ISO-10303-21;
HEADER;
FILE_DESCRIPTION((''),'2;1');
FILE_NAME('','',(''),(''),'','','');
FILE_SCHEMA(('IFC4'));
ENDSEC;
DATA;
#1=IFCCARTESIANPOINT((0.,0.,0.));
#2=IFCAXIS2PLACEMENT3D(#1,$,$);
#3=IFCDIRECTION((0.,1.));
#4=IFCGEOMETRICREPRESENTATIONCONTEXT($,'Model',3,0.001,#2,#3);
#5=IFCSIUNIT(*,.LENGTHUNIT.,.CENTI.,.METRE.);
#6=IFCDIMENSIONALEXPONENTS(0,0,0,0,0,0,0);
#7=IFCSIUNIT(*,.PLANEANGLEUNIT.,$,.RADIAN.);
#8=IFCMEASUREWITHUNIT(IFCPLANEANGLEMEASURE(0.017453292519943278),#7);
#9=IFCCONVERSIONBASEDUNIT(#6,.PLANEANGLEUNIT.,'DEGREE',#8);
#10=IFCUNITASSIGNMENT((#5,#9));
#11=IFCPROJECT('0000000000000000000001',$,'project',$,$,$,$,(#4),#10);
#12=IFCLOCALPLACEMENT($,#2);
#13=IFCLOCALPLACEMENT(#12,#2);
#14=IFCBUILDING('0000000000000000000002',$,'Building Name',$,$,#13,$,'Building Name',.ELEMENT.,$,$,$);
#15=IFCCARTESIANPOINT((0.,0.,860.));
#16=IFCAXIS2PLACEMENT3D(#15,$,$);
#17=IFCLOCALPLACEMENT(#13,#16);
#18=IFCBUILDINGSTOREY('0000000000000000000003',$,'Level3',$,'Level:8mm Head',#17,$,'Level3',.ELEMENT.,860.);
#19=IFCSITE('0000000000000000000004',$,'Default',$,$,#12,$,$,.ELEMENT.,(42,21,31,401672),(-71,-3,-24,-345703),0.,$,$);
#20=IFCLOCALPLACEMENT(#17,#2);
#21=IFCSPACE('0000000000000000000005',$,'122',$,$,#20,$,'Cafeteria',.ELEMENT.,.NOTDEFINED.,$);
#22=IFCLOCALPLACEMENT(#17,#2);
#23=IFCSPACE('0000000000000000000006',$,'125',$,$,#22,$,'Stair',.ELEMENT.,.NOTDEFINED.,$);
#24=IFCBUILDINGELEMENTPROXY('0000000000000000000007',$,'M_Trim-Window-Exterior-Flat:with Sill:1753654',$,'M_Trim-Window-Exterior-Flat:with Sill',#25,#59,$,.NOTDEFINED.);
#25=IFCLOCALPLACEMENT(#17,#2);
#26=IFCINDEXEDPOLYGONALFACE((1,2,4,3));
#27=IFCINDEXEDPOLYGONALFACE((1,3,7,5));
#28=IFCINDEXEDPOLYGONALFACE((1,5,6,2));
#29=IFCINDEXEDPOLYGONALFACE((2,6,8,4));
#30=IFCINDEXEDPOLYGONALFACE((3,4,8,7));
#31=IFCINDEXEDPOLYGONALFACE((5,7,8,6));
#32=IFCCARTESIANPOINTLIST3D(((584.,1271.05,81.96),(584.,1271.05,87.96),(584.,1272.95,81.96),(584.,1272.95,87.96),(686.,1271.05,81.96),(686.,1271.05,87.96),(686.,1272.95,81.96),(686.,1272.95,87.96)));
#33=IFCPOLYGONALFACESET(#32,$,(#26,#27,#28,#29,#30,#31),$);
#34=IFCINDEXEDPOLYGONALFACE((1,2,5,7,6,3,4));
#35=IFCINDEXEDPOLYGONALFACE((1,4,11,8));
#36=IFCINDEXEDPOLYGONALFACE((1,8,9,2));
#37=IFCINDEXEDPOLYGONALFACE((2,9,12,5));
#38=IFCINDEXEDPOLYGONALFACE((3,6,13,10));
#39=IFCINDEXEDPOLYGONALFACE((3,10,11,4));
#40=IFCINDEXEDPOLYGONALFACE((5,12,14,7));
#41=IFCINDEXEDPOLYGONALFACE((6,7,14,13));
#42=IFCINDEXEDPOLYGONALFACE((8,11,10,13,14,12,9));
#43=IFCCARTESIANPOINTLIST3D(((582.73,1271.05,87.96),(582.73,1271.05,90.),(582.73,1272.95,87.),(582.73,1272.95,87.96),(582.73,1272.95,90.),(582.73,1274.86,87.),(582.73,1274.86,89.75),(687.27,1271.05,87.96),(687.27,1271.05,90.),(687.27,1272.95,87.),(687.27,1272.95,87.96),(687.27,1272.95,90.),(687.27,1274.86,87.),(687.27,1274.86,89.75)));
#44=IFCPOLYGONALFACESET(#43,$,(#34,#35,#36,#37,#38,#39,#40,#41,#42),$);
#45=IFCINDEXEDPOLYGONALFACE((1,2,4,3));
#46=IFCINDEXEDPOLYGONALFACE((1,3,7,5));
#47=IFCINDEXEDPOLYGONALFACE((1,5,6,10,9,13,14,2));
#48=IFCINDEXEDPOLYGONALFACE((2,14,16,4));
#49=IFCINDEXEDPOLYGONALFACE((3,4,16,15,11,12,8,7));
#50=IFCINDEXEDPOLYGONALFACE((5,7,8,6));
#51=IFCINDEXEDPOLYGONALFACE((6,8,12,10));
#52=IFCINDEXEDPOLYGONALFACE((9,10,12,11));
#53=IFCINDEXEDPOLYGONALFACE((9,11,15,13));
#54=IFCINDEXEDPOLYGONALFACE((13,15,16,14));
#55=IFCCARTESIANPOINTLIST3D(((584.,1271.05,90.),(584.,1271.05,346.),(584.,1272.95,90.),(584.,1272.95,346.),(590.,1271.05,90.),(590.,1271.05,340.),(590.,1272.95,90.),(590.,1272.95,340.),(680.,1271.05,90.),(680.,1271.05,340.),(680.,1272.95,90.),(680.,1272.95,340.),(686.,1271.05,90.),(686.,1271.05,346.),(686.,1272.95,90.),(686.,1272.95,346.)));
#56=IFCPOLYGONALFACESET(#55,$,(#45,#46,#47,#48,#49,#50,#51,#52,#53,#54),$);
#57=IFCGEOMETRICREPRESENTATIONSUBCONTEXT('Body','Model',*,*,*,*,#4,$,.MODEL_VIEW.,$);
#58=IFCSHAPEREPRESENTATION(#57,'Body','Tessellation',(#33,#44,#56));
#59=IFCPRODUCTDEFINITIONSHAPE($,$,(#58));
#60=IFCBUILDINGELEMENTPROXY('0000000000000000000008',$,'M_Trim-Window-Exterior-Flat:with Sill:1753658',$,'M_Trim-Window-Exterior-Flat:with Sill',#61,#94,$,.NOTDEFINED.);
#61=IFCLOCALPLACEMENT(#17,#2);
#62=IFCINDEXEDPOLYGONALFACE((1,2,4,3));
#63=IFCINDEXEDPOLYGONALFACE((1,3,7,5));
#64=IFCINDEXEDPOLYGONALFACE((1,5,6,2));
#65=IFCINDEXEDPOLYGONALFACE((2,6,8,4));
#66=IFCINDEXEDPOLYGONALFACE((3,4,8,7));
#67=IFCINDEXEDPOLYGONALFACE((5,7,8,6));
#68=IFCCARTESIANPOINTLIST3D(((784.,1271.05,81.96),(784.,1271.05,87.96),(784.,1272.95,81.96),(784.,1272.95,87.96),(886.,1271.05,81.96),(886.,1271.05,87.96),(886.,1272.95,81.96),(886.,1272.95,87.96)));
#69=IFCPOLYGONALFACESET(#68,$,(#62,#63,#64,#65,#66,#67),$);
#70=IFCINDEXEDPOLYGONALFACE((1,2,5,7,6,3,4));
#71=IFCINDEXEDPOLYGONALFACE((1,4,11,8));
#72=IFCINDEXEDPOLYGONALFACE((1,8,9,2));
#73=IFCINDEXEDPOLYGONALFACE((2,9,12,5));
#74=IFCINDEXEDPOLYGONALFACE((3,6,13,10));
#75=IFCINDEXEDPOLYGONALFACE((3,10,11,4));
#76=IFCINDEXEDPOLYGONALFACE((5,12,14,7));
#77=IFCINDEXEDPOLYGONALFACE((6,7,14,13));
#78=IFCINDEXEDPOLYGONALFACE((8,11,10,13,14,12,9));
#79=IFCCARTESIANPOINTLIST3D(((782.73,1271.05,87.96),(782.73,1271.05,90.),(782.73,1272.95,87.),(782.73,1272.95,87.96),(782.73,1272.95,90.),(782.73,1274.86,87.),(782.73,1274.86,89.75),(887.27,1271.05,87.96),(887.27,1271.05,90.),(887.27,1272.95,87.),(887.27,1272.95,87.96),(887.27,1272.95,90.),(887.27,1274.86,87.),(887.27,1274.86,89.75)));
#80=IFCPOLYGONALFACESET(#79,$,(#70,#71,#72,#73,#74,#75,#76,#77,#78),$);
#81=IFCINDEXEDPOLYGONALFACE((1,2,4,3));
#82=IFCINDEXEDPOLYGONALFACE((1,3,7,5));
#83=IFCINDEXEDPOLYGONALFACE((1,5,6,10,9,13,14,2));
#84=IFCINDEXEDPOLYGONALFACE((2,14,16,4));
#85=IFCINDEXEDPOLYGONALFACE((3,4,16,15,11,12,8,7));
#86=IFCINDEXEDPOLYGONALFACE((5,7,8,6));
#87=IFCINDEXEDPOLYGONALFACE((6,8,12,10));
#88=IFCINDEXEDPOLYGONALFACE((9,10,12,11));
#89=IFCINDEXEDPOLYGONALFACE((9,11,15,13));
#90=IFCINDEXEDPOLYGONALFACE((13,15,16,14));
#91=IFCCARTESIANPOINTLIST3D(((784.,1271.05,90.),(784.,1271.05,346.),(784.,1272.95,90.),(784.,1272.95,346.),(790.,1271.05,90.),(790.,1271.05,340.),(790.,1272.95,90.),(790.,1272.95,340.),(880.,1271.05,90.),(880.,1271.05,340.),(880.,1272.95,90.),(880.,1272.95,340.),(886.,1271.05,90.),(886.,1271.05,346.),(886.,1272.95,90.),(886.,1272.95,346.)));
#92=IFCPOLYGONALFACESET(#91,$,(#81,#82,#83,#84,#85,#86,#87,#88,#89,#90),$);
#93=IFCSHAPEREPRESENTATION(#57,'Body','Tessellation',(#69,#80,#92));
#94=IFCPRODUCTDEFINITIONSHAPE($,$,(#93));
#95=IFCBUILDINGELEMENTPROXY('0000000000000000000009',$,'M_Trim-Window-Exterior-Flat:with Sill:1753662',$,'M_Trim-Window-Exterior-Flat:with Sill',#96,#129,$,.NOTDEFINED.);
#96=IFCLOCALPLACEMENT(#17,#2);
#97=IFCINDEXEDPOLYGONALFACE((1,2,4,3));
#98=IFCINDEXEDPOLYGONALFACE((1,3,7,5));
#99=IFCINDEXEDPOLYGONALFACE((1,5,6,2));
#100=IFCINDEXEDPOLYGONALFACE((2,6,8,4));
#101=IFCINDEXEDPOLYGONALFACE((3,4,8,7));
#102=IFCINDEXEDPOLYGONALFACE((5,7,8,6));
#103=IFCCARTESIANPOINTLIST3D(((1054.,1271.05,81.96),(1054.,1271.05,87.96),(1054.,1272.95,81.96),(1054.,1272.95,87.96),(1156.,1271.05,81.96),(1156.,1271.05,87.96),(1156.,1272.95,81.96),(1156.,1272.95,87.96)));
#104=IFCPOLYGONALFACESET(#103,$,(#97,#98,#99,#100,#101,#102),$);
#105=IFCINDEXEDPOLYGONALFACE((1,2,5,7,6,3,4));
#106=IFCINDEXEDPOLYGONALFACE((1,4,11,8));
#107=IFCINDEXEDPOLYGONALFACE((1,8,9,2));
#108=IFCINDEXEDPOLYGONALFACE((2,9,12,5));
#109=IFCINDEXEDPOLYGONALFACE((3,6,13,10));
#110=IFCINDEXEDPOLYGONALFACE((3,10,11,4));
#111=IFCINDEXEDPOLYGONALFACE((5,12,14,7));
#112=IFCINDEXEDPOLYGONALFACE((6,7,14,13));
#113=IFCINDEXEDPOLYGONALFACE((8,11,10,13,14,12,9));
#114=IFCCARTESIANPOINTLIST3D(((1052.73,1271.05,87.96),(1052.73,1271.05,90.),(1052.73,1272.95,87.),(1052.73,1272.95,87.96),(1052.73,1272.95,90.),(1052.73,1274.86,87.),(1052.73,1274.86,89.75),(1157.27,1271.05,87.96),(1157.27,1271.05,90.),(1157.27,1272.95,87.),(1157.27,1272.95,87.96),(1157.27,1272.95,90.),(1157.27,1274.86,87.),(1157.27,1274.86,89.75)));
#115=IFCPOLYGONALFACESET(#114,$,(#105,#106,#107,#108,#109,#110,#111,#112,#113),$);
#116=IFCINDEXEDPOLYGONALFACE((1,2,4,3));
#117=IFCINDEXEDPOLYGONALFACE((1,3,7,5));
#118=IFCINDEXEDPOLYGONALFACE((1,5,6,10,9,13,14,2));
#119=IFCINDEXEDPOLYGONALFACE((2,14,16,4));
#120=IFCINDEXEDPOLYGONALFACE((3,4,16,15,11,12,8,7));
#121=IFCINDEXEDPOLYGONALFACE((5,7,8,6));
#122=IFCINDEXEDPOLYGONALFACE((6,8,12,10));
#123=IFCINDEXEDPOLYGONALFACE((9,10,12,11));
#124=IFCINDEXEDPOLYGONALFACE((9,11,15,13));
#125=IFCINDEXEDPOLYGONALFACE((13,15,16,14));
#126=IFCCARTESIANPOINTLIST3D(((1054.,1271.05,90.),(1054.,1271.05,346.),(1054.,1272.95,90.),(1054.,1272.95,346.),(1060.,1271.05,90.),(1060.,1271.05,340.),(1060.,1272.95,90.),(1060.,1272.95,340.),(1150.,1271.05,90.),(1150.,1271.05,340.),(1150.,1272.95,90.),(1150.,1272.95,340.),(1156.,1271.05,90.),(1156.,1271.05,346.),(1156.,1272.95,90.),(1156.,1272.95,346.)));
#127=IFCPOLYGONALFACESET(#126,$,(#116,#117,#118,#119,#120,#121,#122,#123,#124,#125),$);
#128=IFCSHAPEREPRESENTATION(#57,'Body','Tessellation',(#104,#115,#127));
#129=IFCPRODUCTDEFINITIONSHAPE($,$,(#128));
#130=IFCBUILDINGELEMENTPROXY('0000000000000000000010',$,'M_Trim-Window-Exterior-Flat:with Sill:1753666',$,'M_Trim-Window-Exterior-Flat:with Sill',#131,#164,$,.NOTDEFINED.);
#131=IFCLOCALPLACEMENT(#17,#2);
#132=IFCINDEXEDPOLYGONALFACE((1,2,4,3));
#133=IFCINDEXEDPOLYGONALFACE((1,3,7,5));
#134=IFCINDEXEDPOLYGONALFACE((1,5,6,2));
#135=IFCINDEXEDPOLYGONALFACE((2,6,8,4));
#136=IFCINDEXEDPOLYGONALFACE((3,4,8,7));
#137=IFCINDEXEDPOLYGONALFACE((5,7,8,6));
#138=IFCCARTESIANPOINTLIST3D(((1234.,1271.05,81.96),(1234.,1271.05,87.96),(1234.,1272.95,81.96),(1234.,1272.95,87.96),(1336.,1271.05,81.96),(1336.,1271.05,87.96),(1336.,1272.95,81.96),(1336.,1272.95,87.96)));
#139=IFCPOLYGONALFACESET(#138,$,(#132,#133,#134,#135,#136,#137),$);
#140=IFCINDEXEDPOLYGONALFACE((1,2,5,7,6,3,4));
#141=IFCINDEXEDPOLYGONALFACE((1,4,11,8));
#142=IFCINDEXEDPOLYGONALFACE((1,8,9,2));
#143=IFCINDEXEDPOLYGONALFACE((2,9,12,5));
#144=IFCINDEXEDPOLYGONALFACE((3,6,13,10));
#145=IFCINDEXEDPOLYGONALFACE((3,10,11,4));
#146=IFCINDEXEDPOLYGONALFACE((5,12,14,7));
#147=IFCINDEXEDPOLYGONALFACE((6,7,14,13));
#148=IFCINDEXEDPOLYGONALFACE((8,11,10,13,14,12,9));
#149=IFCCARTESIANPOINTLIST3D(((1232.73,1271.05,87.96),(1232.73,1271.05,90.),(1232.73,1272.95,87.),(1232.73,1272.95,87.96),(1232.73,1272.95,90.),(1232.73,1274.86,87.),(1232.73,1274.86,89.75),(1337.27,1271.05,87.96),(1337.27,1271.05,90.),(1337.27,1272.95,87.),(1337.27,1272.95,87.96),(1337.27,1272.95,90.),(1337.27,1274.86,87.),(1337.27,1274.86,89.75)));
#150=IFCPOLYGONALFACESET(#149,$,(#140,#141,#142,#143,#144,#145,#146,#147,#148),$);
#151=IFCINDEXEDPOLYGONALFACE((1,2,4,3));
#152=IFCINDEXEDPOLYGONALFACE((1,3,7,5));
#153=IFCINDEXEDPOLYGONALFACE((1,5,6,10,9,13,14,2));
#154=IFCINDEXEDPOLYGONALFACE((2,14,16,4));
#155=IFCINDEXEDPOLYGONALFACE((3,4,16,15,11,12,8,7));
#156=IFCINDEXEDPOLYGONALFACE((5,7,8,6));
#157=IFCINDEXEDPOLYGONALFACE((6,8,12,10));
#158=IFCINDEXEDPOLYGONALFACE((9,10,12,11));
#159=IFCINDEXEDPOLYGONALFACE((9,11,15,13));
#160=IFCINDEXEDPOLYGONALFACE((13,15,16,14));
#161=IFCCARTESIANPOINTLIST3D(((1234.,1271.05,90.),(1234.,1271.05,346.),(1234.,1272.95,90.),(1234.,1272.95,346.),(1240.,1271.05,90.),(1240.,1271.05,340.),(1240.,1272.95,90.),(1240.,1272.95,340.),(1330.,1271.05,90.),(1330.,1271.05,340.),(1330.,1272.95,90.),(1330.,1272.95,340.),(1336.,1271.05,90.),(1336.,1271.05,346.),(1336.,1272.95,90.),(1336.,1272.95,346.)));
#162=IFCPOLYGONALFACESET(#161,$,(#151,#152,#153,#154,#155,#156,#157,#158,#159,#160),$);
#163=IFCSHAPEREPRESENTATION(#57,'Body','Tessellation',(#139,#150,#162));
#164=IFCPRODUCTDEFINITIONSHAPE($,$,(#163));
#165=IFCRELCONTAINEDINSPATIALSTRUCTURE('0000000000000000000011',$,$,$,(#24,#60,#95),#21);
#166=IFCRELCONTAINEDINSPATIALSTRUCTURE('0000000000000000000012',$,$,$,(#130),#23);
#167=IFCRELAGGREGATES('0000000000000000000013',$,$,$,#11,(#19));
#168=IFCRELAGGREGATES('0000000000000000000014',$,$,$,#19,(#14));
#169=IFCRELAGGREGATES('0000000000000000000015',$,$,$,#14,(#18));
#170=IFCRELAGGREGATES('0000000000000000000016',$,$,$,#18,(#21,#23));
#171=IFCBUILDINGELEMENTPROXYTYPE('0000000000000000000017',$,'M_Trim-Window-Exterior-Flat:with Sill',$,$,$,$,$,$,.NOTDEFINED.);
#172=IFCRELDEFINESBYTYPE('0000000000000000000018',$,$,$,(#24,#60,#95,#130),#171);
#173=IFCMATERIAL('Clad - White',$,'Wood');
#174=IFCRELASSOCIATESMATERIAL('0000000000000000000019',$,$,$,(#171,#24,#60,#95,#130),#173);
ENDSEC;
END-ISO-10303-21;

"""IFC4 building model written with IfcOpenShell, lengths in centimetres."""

from ifc_helpers import new_model, entity, si_unit, converted_unit, direction, frame, origin, place, context, subcontext, project, spatial, indexed_curve, outline, extrude, source, transform, mapped, material, type_object, type_shapes, element, save


model = new_model("IFC4")

# Units and contexts
model_context = context("Model", 3, precision=0.001, world=origin(), true_north=direction((0.0, 1.0)))
body_context = subcontext(model_context, "Body", "Model", "MODEL_VIEW")
ifc_project = project(units=[si_unit("LENGTHUNIT", "METRE", prefix="CENTI"), converted_unit("PLANEANGLEUNIT", "DEGREE", entity("IfcPlaneAngleMeasure", 0.017453292519943278), si_unit("PLANEANGLEUNIT", "RADIAN"), dimensions=[0, 0, 0, 0, 0, 0, 0])], contexts=[model_context])

# Site, building, storey
site_placement = place(None, origin())
site = spatial("IfcSite", under=ifc_project, at=site_placement, Name="Default", CompositionType="ELEMENT", RefLatitude=(42, 21, 31, 401672), RefLongitude=(-71, -3, -24, -345703), RefElevation=0.0)
building_placement = place(site_placement, origin())
building = spatial("IfcBuilding", under=site, at=building_placement, Name="Building Name", LongName="Building Name", CompositionType="ELEMENT")
storey_placement = place(building_placement, frame((0.0, 0.0, 860.0)))
storey = spatial("IfcBuildingStorey", under=building, at=storey_placement, Name="Level3", ObjectType="Level:8mm Head", LongName="Level3", CompositionType="ELEMENT", Elevation=860.0)

# Shared definitions
ifc_material_1 = material(Name="Clad - White", Category="Wood")

# Shared definitions
space_1_placement = place(storey_placement, origin())
space_1 = spatial("IfcSpace", under=storey, at=space_1_placement, Name="122", LongName="Cafeteria", CompositionType="ELEMENT", PredefinedType="NOTDEFINED")

# Building element proxies
building_element_proxy_type_1 = type_object("IfcBuildingElementProxyType", Name="M_Trim-Window-Exterior-Flat:with Sill", PredefinedType="NOTDEFINED", material=ifc_material_1)
shared_shape_1 = source(origin(), body_context, "Body", "SweptSolid", [
    extrude(outline(indexed_curve([(-51.0, -3.0), (51.0, -3.0), (51.0, 3.0), (-51.0, 3.0), (-51.0, -3.0)], self_intersect=False)), frame((0.0, -255.04, 0.0), z_axis=(0.0, 0.0, 1.0), x_axis=(-1.0, 0.0, 0.0)), (0.0, 0.0, 1.0), 1.9),
    extrude(outline(indexed_curve([(-1.9, -1.52), (0.0, -1.52), (0.0, -0.57), (1.9, -0.57), (1.9, 1.48), (0.0, 1.48), (-1.9, 1.23), (-1.9, -1.52)], self_intersect=False)), frame((-52.27, -251.48, 1.9), z_axis=(1.0, 0.0, 0.0), x_axis=(0.0, 0.0, -1.0)), (0.0, 0.0, 1.0), 104.54),
    extrude(outline(indexed_curve([(-129.5, -51.0), (126.5, -51.0), (126.5, -45.0), (-123.5, -45.0), (-123.5, 45.0), (126.5, 45.0), (126.5, 51.0), (-129.5, 51.0), (-129.5, -51.0)], self_intersect=False)), frame((0.0, -123.5, 0.0), z_axis=(0.0, 0.0, 1.0), x_axis=(0.0, -1.0, 0.0)), (0.0, 0.0, 1.0), 1.9),
])
type_shapes(building_element_proxy_type_1, [shared_shape_1])
for number, where, z_axis, x_axis, name in (
    (1, (635.0, 1271.05, 340.0), (0.0, 1.0, 0.0), (-1.0, 0.0, 0.0), "M_Trim-Window-Exterior-Flat:with Sill:1753654"),
    (2, (835.0, 1271.05, 340.0), (0.0, 1.0, 0.0), (-1.0, 0.0, 0.0), "M_Trim-Window-Exterior-Flat:with Sill:1753658"),
    (3, (1105.0, 1271.05, 340.0), (0.0, 1.0, 0.0), (-1.0, 0.0, 0.0), "M_Trim-Window-Exterior-Flat:with Sill:1753662"),
):
    element("IfcBuildingElementProxy", number, at=place(space_1_placement, frame(where, z_axis=z_axis, x_axis=x_axis)), inside=space_1, type_object=building_element_proxy_type_1, material=ifc_material_1, Name=name, ObjectType="M_Trim-Window-Exterior-Flat:with Sill", PredefinedType="NOTDEFINED", context=body_context, shape_type="MappedRepresentation", body=[
        mapped(shared_shape_1, transform((0.0, 0.0, 0.0), scale=1.0)),
    ])

# Shared definitions
space_2_placement = place(storey_placement, origin())
space_2 = spatial("IfcSpace", under=storey, at=space_2_placement, Name="125", LongName="Stair", CompositionType="ELEMENT", PredefinedType="NOTDEFINED")

# Building element proxy
proxy_1_placement = place(space_2_placement, frame((1285.0, 1271.05, 340.0), z_axis=(0.0, 1.0, 0.0), x_axis=(-1.0, 0.0, 0.0)))
element("IfcBuildingElementProxy", 4, at=proxy_1_placement, inside=space_2, type_object=building_element_proxy_type_1, material=ifc_material_1, Name="M_Trim-Window-Exterior-Flat:with Sill:1753666", ObjectType="M_Trim-Window-Exterior-Flat:with Sill", PredefinedType="NOTDEFINED", context=body_context, shape_type="MappedRepresentation", body=[
    mapped(shared_shape_1, transform((0.0, 0.0, 0.0), scale=1.0)),
])

save(model, "model.ifc")
